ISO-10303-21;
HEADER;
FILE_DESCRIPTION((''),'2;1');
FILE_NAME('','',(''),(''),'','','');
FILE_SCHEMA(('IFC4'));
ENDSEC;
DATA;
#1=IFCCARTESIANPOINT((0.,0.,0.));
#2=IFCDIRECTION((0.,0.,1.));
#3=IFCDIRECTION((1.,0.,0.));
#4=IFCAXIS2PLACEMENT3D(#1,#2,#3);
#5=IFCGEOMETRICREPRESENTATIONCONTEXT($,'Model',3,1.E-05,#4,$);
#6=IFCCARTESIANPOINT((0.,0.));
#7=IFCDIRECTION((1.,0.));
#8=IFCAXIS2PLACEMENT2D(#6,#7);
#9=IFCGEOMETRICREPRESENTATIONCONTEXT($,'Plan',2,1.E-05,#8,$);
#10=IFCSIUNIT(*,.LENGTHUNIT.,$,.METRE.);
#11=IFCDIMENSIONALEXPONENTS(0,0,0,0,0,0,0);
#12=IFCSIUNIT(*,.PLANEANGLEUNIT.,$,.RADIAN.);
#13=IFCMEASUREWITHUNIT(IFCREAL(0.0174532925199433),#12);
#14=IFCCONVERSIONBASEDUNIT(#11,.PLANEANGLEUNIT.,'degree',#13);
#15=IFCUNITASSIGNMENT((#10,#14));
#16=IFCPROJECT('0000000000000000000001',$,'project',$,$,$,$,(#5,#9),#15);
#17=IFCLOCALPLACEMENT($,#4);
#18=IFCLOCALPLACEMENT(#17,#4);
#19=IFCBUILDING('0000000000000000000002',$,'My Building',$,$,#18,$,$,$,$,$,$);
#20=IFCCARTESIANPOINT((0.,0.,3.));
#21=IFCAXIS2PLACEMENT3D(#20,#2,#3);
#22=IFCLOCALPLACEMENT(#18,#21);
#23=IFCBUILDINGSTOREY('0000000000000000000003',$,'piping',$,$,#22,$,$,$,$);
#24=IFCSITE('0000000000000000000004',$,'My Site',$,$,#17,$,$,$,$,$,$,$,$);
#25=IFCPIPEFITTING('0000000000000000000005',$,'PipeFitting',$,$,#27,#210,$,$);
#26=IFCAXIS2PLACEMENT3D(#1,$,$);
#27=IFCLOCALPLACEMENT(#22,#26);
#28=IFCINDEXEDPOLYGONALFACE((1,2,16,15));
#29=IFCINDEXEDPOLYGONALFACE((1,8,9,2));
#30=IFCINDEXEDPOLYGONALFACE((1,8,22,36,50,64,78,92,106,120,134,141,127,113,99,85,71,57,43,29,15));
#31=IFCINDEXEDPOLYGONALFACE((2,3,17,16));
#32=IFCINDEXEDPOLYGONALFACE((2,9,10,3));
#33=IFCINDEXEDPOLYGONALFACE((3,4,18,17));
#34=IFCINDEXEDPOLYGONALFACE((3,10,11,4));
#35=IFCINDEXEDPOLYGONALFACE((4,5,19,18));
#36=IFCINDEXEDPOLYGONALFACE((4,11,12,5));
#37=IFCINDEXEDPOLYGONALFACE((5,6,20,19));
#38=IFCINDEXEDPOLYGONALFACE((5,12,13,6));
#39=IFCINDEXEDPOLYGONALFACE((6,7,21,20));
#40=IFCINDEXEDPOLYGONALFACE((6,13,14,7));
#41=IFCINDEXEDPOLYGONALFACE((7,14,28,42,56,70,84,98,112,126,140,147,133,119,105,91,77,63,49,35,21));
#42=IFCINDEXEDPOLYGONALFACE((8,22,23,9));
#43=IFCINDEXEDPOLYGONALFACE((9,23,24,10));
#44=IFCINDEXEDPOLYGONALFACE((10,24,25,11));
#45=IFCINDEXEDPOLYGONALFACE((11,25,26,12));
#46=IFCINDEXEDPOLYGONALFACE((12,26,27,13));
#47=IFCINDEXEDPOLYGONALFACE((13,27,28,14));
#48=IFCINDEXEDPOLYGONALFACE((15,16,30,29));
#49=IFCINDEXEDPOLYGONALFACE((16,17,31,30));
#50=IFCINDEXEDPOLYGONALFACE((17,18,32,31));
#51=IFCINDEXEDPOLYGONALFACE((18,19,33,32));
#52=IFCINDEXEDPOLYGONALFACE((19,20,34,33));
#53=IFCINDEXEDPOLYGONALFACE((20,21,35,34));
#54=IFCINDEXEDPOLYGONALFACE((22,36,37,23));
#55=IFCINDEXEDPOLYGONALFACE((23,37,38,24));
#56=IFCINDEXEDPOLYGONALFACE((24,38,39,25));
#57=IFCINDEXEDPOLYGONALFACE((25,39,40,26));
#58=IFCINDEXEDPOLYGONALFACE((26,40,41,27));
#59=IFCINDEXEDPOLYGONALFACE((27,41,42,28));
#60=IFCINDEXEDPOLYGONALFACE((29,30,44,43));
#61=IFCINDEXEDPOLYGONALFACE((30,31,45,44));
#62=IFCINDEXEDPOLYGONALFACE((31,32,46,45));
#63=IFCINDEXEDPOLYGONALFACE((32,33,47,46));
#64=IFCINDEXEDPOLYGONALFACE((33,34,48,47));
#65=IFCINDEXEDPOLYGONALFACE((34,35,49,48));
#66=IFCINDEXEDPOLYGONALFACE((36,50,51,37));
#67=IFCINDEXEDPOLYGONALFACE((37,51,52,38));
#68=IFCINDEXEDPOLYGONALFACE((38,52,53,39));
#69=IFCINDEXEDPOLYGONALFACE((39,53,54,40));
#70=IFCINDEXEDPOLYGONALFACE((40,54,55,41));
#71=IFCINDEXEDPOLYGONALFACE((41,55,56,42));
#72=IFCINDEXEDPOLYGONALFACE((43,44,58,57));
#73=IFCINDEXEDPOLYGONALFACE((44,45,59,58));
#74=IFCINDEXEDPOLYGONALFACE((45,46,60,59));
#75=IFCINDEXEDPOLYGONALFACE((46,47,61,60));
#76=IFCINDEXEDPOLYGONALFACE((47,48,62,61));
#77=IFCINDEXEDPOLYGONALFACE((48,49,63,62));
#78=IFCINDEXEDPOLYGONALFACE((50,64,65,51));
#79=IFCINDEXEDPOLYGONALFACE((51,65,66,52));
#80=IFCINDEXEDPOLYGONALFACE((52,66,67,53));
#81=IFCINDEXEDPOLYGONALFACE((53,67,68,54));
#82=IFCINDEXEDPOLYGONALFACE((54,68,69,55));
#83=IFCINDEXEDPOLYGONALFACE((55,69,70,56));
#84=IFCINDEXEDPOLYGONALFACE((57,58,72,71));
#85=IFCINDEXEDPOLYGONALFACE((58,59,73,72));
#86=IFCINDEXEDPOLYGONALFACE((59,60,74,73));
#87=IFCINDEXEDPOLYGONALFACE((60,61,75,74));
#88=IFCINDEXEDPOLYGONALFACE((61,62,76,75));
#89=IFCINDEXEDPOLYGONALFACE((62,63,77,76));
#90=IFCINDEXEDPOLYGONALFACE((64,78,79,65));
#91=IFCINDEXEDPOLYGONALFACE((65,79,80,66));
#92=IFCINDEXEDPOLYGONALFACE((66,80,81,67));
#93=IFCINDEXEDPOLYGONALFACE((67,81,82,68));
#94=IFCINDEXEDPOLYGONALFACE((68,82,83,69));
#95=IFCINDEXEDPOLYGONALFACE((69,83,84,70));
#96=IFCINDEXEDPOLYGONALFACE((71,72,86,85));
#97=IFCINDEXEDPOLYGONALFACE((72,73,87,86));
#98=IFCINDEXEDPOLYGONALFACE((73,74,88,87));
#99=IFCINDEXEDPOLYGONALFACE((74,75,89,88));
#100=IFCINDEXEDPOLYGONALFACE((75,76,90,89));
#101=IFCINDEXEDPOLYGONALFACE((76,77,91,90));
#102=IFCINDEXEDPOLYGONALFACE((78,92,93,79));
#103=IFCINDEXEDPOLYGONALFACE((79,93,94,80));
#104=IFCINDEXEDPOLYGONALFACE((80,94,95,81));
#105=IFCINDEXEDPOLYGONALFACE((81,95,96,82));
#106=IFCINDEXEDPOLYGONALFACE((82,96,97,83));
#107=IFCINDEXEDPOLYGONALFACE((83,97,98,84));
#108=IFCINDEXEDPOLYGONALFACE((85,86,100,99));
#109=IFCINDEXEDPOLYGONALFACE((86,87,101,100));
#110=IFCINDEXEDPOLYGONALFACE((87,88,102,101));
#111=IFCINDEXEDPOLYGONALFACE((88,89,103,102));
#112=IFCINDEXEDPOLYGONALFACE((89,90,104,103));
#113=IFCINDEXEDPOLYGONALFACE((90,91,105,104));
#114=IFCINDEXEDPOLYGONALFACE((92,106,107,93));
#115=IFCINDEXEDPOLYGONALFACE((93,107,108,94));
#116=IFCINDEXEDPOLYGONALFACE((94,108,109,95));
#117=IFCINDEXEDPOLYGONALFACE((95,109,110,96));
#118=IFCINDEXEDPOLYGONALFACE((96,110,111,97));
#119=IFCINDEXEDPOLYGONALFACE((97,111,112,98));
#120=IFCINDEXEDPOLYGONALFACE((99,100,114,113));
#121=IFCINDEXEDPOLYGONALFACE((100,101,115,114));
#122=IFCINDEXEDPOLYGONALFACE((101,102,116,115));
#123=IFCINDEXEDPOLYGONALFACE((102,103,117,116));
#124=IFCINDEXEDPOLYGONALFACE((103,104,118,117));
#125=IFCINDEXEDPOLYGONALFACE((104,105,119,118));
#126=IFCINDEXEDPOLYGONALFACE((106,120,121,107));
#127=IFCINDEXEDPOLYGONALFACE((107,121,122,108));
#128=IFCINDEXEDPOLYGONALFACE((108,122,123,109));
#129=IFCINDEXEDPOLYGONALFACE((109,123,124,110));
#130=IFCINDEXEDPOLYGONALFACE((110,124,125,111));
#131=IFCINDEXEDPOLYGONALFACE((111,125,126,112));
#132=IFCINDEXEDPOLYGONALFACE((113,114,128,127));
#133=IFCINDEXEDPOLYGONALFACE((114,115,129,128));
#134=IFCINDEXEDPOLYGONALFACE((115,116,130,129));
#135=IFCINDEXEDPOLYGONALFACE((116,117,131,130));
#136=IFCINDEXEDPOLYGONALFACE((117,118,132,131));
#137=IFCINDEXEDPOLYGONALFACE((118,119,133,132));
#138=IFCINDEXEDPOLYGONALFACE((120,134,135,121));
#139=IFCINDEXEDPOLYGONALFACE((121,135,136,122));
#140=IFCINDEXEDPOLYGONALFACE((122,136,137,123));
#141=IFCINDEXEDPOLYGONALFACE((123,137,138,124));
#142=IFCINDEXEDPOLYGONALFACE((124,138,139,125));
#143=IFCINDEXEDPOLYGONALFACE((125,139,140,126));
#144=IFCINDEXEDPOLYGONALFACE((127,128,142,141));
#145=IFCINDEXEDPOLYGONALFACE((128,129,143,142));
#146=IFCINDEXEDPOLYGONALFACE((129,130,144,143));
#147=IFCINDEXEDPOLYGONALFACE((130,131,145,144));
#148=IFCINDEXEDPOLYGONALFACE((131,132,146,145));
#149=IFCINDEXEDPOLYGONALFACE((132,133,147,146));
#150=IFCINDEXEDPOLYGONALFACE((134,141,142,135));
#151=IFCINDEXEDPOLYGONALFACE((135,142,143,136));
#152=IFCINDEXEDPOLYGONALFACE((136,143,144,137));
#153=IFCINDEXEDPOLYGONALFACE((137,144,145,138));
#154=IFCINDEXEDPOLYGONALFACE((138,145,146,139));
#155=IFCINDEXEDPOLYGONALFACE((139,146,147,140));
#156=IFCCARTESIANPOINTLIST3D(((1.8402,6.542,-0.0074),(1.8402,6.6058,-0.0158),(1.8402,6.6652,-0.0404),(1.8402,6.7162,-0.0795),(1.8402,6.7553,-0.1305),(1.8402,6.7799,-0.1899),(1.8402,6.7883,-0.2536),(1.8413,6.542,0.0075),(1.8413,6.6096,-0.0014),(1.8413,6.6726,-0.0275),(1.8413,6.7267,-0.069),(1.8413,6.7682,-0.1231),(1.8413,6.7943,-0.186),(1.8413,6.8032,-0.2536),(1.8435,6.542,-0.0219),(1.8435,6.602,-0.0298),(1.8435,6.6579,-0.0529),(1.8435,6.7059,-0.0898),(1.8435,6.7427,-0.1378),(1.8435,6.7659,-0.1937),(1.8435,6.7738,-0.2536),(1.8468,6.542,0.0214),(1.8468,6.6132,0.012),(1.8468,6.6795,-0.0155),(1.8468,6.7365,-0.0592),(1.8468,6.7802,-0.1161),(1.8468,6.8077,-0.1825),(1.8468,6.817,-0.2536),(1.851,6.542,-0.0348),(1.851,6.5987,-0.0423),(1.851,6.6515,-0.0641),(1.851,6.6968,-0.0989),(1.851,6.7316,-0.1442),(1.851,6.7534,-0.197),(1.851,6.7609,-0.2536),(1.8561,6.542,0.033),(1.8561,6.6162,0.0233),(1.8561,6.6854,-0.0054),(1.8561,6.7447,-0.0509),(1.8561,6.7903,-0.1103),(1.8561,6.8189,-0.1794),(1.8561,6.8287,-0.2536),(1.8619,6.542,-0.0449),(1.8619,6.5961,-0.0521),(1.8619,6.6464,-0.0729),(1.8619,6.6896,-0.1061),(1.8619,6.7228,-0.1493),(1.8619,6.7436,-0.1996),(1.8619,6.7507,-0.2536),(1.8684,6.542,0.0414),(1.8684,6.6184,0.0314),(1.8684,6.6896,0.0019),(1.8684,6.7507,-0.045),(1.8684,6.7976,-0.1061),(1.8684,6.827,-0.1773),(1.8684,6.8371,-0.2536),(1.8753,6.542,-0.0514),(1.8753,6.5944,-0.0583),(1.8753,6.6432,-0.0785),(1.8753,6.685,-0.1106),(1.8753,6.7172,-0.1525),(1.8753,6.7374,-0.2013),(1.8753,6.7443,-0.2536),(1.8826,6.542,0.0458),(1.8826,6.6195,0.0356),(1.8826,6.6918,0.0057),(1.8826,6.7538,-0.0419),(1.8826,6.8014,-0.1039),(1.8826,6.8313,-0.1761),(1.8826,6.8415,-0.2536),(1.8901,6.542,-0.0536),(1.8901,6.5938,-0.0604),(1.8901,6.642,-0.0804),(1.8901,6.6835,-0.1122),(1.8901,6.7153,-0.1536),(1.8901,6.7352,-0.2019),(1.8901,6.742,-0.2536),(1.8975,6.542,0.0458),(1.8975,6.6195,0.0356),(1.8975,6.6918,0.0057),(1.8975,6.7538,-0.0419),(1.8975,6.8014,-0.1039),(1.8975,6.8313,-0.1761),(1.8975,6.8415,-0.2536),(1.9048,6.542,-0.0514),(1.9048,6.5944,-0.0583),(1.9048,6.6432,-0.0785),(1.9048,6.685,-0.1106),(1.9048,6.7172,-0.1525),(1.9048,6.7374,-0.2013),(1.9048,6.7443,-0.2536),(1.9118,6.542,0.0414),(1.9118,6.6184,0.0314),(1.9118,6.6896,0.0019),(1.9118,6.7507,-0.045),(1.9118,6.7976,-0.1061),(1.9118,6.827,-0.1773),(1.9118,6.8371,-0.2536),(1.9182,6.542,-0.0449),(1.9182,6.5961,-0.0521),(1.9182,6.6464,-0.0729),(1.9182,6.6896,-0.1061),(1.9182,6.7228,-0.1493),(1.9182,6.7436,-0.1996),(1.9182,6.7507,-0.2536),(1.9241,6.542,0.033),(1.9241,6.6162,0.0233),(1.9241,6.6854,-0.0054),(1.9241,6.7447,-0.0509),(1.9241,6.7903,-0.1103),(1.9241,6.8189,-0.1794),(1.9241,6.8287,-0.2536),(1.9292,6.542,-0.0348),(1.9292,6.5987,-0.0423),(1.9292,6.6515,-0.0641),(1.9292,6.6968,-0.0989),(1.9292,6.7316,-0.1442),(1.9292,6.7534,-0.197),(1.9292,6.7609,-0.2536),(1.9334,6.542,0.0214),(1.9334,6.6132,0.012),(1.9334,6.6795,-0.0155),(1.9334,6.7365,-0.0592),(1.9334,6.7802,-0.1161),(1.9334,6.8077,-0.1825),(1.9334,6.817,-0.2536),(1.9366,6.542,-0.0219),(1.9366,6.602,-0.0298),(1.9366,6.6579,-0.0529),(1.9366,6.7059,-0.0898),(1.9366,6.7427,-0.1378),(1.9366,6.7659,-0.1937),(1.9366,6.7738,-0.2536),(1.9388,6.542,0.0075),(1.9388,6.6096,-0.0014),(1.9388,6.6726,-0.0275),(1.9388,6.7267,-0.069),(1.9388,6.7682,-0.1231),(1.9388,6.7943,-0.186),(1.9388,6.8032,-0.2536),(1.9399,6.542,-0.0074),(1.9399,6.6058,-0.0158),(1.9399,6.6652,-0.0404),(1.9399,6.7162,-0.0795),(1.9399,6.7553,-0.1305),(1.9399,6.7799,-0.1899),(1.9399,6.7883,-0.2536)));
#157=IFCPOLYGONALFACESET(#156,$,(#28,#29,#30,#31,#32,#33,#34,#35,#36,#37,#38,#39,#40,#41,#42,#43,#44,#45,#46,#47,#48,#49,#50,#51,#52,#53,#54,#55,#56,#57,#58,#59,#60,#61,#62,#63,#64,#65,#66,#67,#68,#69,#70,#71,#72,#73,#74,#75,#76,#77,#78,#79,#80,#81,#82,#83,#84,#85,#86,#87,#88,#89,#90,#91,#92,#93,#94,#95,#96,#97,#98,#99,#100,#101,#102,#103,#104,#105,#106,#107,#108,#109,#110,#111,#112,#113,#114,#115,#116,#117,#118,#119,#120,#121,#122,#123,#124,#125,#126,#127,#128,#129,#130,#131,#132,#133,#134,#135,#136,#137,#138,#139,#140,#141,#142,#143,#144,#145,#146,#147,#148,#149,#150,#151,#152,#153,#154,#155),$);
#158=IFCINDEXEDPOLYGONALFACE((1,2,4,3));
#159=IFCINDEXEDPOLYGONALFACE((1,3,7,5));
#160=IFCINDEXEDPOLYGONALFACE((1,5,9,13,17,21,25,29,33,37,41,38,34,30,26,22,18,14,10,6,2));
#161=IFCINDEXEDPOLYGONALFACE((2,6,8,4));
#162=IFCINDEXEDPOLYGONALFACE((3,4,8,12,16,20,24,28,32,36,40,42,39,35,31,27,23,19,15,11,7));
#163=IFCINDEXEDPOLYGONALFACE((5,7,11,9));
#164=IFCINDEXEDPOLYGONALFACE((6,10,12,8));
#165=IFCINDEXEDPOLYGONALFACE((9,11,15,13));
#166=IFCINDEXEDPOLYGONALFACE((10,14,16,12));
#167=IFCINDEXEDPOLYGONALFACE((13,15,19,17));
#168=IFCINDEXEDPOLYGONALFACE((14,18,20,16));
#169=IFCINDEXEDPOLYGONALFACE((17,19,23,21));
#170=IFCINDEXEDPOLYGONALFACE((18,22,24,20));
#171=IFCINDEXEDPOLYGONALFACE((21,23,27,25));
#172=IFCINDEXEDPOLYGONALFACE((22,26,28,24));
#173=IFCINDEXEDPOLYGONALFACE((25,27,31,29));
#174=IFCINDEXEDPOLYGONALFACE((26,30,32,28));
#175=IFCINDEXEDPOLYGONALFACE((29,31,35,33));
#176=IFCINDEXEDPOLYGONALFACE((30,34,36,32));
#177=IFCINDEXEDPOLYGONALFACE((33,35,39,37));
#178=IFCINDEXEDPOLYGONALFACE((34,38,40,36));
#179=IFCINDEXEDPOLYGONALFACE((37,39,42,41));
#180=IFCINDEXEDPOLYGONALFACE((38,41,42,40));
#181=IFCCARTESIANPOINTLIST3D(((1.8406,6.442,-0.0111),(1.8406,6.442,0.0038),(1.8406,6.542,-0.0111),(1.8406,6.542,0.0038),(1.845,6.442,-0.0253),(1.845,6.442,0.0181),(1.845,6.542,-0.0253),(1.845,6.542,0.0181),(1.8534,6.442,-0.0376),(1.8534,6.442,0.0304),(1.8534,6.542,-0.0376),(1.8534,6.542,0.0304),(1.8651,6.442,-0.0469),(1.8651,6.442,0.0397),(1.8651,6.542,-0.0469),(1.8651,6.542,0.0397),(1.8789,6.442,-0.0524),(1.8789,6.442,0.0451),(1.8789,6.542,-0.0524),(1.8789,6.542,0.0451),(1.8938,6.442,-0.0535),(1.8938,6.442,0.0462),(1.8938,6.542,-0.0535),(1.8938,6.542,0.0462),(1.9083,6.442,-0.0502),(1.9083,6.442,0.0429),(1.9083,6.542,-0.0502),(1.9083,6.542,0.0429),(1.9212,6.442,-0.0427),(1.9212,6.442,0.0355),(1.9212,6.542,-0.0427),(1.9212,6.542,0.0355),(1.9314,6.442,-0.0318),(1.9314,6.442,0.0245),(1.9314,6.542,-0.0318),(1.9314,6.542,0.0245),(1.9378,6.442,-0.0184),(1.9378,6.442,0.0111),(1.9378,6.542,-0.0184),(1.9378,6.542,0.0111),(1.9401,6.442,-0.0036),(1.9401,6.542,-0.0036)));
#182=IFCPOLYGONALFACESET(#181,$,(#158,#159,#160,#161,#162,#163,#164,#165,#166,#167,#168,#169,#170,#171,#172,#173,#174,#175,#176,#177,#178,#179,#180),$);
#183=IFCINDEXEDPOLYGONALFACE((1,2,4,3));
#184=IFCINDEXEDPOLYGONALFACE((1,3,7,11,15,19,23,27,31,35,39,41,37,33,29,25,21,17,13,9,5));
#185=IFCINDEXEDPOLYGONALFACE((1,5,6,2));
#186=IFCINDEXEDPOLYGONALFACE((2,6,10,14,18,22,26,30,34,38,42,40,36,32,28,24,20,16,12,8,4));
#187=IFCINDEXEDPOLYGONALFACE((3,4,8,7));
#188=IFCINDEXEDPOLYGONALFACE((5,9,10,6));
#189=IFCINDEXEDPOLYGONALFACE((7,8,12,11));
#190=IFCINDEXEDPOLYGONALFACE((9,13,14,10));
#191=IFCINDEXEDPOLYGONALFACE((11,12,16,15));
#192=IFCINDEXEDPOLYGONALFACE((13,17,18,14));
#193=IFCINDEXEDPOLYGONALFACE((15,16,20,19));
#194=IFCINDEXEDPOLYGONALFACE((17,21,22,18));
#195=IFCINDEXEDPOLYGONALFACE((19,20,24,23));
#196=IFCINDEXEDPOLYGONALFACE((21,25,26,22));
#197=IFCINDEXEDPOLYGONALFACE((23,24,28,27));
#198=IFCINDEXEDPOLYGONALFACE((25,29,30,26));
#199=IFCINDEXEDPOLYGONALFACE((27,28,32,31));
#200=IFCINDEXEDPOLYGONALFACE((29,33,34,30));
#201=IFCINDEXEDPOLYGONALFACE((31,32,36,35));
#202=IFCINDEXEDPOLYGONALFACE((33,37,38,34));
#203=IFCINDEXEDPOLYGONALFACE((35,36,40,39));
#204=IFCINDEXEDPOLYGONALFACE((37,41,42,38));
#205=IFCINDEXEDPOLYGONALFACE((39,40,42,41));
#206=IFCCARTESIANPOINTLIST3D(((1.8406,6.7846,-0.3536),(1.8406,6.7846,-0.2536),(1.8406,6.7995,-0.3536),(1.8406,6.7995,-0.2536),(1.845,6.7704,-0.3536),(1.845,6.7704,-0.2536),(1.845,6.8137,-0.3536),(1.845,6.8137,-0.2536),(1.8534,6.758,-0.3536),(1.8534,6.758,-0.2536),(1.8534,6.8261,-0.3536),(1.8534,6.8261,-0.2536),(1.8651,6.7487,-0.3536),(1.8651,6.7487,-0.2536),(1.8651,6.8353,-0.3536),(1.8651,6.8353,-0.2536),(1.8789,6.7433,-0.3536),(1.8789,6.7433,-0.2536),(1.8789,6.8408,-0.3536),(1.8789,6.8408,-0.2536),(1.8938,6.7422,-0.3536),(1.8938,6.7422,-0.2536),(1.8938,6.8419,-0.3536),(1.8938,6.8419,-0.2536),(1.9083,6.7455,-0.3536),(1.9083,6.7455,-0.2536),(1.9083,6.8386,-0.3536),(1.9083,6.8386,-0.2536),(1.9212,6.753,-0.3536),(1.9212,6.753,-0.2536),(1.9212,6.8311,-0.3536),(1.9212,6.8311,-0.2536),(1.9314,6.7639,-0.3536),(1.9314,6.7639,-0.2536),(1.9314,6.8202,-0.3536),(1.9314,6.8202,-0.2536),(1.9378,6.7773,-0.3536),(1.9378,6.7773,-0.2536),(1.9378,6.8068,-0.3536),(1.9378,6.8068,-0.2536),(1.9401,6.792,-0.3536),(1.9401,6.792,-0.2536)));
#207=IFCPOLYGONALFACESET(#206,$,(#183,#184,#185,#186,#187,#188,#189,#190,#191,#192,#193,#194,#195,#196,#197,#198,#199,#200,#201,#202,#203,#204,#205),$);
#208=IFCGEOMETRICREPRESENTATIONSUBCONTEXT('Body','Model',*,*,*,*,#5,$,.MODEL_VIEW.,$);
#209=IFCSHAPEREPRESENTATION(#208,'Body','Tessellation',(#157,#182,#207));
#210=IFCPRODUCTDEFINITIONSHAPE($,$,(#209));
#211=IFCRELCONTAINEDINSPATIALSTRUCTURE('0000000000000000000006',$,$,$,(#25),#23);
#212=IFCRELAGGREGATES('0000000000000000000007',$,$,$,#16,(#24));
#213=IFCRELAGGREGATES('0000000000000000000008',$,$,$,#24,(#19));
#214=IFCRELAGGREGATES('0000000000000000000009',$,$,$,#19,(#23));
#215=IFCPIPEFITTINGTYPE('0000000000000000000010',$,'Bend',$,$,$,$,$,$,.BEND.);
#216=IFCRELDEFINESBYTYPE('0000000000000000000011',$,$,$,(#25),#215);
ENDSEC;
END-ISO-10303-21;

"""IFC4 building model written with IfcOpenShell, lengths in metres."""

from ifc_helpers import new_model, entity, si_unit, converted_unit, frame, origin_with_axes, origin_2d_with_axis, place, context, subcontext, project, spatial, circle, extrude, source, transform, mapped, type_object, type_shapes, element, save


model = new_model("IFC4")

# Units and contexts
model_context = context("Model", 3, precision=1e-05, world=origin_with_axes())
plan_context = context("Plan", 2, precision=1e-05, world=origin_2d_with_axis())
body_context = subcontext(model_context, "Body", "Model", "MODEL_VIEW")
ifc_project = project(units=[si_unit("LENGTHUNIT", "METRE"), converted_unit("PLANEANGLEUNIT", "degree", entity("IfcReal", 0.0174532925199433), si_unit("PLANEANGLEUNIT", "RADIAN"), dimensions=[0, 0, 0, 0, 0, 0, 0])], contexts=[model_context, plan_context])

# Site, building, storey
site_placement = place(None, origin_with_axes())
site = spatial("IfcSite", under=ifc_project, at=site_placement, Name="My Site")
building_placement = place(site_placement, origin_with_axes())
building = spatial("IfcBuilding", under=site, at=building_placement, Name="My Building")
storey_placement = place(building_placement, frame((0.0, 0.0, 3.0), z_axis=(0.0, 0.0, 1.0), x_axis=(1.0, 0.0, 0.0)))
storey = spatial("IfcBuildingStorey", under=building, at=storey_placement, Name="piping")

# Pipe fitting
pipe_fitting_type = type_object("IfcPipeFittingType", Name="Bend", PredefinedType="BEND")
shared_shape = source(origin_with_axes(), body_context, "Body", "SolidModel", [
    entity("IfcSweptDiskSolid", entity("IfcIndexedPolyCurve", entity("IfcCartesianPointList3D", [[0.0, 0.0, -0.1], [0.0, -0.0732, -0.2768], [0.0, -0.25, -0.35]]), [entity("IfcArcIndex", [1, 2, 3])]), 0.05),
    extrude(circle(Radius=0.05), origin_with_axes(), (0.0, 0.0, -1.0), 0.1),
    extrude(circle(Radius=0.05), frame((0.0, -0.25, -0.35), z_axis=(0.0, -1.0, 0.0), x_axis=(1.0, 0.0, 0.0)), (0.0, 0.0, 1.0), 0.1),
])
type_shapes(pipe_fitting_type, [shared_shape])
for number, where, z_axis, x_axis, name in (
    (1, (1.8901, 6.442, -0.0036), (0.0, -1.0, 0.0), (1.0, 0.0, 0.0), "PipeFitting"),
):
    element("IfcPipeFitting", number, at=place(storey_placement, frame(where, z_axis=z_axis, x_axis=x_axis)), inside=storey, type_object=pipe_fitting_type, Name=name, context=body_context, shape_type="MappedRepresentation", body=[
        mapped(shared_shape, transform((0.0, 0.0, 0.0), x_axis=(1.0, 0.0, 0.0), y_axis=(0.0, 1.0, 0.0), z_axis=(0.0, 0.0, 1.0), scale=1.0)),
    ])

save(model, "model.ifc")
